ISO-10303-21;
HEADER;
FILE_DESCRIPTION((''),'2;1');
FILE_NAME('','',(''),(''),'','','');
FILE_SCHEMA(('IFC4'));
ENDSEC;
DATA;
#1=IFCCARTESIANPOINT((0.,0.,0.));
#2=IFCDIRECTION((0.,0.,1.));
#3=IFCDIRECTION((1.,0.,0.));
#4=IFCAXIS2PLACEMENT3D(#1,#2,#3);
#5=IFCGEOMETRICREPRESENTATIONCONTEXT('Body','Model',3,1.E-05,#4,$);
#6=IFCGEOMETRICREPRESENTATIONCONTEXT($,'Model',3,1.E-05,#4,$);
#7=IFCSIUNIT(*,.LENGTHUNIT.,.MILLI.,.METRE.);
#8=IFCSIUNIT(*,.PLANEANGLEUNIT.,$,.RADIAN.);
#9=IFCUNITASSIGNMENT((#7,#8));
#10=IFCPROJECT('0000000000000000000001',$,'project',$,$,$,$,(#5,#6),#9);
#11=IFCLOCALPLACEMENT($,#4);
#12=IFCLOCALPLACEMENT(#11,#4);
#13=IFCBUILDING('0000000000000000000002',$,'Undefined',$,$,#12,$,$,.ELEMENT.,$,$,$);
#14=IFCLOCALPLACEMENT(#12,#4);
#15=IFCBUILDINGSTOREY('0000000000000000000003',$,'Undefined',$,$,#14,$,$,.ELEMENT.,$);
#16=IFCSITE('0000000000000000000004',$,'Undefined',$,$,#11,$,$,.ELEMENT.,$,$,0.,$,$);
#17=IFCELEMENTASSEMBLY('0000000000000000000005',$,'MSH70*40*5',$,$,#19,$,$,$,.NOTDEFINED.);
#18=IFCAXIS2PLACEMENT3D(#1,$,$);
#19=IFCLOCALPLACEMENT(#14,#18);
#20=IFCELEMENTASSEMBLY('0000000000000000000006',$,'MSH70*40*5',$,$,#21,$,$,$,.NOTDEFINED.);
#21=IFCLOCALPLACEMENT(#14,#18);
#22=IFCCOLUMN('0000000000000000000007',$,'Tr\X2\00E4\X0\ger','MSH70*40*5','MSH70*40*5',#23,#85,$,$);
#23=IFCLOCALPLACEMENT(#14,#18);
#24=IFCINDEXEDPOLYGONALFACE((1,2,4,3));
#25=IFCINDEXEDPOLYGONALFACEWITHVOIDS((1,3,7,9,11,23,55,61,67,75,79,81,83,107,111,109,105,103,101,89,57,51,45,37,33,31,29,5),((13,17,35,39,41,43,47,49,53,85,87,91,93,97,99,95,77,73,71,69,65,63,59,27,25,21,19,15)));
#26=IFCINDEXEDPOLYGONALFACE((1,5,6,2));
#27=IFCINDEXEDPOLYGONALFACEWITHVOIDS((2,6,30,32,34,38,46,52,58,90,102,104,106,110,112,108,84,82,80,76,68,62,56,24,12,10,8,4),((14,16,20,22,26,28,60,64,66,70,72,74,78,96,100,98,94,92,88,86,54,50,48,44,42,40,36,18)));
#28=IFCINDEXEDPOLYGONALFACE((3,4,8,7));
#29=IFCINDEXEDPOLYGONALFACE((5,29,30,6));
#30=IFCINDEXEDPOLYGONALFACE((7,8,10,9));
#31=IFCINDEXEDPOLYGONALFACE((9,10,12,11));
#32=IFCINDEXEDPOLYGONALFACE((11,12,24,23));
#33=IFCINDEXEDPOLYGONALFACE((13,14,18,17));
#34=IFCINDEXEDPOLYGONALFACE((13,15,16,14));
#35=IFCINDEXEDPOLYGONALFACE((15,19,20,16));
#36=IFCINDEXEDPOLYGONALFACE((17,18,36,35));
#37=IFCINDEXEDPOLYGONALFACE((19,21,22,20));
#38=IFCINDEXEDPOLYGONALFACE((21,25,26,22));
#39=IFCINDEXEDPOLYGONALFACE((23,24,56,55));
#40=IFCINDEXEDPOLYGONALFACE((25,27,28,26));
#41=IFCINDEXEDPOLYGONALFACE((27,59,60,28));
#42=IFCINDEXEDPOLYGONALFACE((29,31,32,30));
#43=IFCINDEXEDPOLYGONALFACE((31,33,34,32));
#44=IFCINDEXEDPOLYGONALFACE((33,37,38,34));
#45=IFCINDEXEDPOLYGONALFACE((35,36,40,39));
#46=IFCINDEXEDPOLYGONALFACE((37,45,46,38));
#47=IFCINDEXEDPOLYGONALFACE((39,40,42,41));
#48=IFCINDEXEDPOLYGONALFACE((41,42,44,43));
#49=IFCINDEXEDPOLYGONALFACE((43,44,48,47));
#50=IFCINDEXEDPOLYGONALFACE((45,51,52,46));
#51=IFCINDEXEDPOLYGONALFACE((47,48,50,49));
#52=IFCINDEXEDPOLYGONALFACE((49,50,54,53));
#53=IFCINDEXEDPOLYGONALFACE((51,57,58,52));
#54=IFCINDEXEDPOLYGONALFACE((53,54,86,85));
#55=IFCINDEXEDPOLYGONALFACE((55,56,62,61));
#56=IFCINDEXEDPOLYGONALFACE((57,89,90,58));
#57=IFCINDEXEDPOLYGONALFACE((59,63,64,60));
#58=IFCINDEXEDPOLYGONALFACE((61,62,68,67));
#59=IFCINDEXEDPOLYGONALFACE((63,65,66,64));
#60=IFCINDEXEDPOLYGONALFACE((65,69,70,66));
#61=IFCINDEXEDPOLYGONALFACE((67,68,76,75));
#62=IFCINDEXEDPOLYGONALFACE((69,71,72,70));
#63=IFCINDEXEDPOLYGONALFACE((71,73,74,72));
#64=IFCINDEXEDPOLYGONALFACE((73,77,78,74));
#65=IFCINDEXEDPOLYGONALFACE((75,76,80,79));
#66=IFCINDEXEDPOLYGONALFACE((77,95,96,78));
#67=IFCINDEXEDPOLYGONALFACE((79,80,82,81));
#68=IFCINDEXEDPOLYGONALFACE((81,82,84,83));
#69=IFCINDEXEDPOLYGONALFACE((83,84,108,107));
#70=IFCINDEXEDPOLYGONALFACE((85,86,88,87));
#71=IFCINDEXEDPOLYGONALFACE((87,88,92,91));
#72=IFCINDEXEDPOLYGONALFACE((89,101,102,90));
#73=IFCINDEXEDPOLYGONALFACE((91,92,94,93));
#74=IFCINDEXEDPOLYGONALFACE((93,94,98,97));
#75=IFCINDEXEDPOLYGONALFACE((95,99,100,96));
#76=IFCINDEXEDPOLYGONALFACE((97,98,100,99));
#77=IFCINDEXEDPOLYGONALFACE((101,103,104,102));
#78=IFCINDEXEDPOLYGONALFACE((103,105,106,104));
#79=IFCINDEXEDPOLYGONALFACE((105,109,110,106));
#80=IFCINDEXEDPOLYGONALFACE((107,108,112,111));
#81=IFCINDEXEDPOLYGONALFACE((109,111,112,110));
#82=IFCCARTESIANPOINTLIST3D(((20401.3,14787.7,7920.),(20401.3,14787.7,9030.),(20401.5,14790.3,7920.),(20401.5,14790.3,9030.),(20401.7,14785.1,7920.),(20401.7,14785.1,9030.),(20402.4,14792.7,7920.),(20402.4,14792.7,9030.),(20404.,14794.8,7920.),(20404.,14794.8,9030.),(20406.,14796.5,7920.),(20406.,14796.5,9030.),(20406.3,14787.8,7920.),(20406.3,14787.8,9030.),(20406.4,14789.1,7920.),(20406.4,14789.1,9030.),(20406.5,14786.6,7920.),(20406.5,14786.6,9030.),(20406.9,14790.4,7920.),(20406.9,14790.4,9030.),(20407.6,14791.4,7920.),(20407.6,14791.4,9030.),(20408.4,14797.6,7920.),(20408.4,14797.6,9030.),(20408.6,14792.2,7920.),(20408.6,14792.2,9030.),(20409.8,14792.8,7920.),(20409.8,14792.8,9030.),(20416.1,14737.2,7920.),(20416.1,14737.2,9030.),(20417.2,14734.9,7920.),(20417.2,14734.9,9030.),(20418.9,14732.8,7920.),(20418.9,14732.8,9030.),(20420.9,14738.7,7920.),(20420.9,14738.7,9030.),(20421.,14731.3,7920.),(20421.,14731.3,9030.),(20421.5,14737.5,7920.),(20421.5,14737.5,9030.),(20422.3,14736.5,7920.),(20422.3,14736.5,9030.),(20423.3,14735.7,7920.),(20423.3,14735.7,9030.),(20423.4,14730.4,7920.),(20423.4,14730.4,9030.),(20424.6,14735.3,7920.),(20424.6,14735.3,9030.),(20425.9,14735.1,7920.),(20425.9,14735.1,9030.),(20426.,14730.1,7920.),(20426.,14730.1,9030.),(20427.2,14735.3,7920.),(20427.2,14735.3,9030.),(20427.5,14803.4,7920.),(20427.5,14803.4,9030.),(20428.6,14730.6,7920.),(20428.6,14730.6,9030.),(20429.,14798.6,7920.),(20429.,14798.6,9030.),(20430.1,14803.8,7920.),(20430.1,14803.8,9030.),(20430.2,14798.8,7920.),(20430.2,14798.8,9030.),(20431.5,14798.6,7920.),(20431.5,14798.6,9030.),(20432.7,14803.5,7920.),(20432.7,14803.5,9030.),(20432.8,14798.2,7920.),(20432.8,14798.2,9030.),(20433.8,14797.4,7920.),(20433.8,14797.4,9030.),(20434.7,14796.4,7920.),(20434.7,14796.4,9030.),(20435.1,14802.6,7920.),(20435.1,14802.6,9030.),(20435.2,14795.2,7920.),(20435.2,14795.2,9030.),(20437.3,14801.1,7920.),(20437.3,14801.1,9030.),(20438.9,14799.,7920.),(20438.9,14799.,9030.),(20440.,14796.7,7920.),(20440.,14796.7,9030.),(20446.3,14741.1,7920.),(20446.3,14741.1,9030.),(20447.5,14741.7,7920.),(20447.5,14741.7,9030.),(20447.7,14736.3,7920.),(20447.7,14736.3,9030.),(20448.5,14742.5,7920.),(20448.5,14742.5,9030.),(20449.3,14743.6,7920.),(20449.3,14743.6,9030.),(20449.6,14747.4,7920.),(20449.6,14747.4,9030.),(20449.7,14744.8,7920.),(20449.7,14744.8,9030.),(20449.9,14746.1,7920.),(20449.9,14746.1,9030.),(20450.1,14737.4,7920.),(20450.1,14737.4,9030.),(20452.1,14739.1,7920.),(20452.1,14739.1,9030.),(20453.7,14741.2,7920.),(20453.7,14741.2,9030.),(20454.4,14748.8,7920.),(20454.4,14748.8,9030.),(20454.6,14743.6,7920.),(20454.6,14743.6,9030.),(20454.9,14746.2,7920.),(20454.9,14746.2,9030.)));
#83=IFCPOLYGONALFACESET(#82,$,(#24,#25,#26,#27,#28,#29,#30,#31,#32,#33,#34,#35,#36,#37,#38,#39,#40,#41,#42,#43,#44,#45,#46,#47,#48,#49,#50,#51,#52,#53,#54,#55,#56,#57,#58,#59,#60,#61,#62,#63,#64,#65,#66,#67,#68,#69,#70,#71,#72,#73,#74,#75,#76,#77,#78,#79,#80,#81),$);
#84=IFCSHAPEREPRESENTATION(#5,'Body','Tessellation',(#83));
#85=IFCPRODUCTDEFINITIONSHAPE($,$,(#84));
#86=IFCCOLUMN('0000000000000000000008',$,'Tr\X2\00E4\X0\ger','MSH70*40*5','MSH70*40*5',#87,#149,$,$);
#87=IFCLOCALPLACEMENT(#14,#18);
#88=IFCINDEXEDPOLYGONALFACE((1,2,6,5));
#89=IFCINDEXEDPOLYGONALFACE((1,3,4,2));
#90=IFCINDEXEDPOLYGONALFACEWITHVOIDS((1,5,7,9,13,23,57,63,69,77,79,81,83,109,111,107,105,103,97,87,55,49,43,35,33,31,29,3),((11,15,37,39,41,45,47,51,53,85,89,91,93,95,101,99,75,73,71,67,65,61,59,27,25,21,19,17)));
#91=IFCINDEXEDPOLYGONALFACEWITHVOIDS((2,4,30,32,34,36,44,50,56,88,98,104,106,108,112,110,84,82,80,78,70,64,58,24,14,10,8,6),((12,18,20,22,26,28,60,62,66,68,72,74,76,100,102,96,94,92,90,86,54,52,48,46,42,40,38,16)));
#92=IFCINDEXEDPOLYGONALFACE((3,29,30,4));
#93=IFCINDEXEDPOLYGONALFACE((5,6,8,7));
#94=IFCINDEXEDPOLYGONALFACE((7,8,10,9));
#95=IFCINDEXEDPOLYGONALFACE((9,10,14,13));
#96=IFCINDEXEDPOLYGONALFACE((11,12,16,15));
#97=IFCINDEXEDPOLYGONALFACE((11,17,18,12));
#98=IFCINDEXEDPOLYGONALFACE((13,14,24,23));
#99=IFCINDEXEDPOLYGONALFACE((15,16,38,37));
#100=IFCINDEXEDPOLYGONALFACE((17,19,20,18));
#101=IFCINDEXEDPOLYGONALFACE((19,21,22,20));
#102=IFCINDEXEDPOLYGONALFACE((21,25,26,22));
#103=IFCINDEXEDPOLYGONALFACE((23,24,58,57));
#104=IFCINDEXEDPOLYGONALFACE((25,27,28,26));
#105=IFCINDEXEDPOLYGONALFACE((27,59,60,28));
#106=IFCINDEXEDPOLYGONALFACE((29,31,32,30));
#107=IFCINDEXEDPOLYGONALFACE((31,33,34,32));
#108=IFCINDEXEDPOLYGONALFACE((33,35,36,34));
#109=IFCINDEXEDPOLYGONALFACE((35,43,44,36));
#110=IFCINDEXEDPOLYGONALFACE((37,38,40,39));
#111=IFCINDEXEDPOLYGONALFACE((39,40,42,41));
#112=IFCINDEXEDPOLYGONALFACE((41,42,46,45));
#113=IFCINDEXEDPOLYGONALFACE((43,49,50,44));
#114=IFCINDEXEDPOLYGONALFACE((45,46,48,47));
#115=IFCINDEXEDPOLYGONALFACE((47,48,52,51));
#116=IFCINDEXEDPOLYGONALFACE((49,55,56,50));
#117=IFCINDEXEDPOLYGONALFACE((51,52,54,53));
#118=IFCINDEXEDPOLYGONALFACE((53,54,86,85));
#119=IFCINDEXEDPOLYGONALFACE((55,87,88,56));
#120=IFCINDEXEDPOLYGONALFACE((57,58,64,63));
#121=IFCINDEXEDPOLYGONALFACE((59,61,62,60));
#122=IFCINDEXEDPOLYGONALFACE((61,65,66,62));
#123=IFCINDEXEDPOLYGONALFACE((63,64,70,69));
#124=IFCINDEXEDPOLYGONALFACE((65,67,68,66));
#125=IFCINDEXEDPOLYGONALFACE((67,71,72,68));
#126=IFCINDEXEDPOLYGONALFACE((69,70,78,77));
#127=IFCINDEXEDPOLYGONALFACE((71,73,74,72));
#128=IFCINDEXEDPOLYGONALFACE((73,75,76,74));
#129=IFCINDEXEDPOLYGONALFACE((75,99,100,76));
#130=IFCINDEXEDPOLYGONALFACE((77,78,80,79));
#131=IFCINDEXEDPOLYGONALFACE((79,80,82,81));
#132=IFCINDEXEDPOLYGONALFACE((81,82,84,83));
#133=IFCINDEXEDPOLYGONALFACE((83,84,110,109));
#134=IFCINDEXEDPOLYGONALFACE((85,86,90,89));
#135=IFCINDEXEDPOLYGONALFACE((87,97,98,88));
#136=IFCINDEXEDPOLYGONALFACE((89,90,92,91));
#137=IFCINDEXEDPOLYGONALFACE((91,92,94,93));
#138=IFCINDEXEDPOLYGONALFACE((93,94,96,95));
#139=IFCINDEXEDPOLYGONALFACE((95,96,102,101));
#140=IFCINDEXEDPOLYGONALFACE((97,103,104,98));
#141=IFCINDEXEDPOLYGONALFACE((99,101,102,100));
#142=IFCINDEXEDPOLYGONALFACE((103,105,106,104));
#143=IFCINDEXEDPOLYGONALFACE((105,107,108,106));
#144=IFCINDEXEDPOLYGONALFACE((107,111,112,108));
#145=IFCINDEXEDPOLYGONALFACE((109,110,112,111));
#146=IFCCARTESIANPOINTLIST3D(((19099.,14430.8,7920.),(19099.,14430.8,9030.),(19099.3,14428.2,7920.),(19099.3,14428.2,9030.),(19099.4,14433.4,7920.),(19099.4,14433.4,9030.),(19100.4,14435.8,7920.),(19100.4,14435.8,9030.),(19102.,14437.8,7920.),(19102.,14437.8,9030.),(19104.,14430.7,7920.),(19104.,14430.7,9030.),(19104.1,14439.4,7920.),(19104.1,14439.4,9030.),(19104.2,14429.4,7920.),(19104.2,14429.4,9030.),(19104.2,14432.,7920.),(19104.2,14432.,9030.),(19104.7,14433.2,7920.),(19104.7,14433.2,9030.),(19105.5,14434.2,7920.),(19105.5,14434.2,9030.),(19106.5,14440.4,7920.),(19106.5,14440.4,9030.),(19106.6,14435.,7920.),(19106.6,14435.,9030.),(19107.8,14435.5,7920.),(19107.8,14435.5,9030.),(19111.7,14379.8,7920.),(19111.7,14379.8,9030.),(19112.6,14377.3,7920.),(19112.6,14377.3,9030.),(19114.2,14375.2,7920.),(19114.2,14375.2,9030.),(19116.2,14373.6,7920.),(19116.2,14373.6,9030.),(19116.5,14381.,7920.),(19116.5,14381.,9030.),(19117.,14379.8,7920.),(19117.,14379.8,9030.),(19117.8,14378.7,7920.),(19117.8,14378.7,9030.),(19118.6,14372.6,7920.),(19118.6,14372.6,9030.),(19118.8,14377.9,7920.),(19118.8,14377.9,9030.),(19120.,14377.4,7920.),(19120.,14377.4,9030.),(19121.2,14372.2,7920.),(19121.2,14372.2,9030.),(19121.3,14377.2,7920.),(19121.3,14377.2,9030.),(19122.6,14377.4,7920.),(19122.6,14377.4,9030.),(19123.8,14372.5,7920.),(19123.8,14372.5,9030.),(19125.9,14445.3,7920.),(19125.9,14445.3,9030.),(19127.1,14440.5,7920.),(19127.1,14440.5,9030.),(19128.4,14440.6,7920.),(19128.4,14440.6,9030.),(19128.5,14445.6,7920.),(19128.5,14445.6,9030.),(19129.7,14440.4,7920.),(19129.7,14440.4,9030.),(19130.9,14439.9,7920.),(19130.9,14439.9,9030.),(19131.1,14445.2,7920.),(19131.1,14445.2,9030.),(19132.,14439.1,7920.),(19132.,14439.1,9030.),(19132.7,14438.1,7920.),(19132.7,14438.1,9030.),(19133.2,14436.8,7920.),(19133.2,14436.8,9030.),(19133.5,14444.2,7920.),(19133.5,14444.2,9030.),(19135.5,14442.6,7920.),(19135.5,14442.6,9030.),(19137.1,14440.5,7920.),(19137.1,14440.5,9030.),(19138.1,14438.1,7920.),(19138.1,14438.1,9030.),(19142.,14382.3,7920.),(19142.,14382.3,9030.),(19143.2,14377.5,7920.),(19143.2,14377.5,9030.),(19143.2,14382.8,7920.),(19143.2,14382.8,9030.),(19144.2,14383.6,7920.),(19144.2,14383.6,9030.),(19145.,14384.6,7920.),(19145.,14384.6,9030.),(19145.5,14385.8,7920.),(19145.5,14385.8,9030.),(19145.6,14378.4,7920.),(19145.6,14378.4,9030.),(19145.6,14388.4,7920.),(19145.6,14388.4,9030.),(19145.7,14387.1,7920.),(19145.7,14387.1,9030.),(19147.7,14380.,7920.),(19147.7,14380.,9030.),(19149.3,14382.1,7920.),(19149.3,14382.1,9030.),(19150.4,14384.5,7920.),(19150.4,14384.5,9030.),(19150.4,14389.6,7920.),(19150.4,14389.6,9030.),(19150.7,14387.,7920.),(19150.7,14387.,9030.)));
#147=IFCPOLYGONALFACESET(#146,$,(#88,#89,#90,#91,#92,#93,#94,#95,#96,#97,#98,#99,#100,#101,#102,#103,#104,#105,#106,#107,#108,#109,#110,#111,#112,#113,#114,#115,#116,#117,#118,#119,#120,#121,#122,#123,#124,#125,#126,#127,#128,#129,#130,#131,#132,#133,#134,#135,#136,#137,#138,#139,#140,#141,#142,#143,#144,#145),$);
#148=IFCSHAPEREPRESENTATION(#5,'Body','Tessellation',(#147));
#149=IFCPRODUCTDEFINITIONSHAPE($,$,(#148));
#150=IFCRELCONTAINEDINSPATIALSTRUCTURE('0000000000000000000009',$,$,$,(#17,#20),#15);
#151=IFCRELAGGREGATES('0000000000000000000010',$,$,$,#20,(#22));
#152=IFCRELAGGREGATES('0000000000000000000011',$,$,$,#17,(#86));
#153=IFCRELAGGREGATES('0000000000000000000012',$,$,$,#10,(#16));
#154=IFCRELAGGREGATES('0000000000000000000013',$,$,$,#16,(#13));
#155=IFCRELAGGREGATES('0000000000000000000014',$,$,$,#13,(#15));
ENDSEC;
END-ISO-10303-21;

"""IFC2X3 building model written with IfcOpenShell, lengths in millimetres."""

from ifc_helpers import new_model, si_unit, frame, origin_with_axes, origin_2d_with_axis, place, context, project, spatial, hollow_rectangle, extrude, element, aggregate, save


model = new_model("IFC2X3")

# Units and contexts
model_context_1 = context("Model", 3, precision=1e-05, world=origin_with_axes(), identifier="Body")
model_context_2 = context("Model", 3, precision=1e-05, world=origin_with_axes())
ifc_project = project(units=[si_unit("LENGTHUNIT", "METRE", prefix="MILLI"), si_unit("PLANEANGLEUNIT", "RADIAN")], contexts=[model_context_1, model_context_2])

# Site, building, storey
site_placement = place(None, origin_with_axes())
site = spatial("IfcSite", under=ifc_project, at=site_placement, Name="Undefined", CompositionType="ELEMENT", RefElevation=0.0)
building_placement = place(site_placement, origin_with_axes())
building = spatial("IfcBuilding", under=site, at=building_placement, Name="Undefined", CompositionType="ELEMENT")
storey_placement = place(building_placement, origin_with_axes())
storey = spatial("IfcBuildingStorey", under=building, at=storey_placement, Name="Undefined", CompositionType="ELEMENT")

# Element assembly
assembly_1 = element("IfcElementAssembly", 1, inside=storey, Name="MSH70*40*5", PredefinedType="NOTDEFINED")

# Element assembly, column
assembly_2 = element("IfcElementAssembly", 2, inside=storey, Name="MSH70*40*5", PredefinedType="NOTDEFINED")
column_1_placement = place(storey_placement, frame((20428.1, 14767.0, 7920.0), z_axis=(0.0, 0.0, 1.0), x_axis=(1.0, 0.0, 0.0)))
column_1 = element("IfcColumn", 3, at=column_1_placement, Name="Träger", Description="MSH70*40*5", ObjectType="MSH70*40*5", context=model_context_1, shape_type="SweptSolid", body=[
    extrude(hollow_rectangle(XDim=40.0, YDim=70.0, WallThickness=5.0, InnerFilletRadius=5.0, OuterFilletRadius=10.0, at=origin_2d_with_axis()), frame((0.0, 0.0, 1110.0), z_axis=(0.0, 0.0, -1.0), x_axis=(-0.957319, -0.289033, 0.000005)), (0.0, 0.0, 1.0), 1110.0),
])
aggregate(assembly_2, [column_1])

# Column
column_2_placement = place(storey_placement, frame((19124.9, 14408.9, 7920.0), z_axis=(0.0, 0.0, 1.0), x_axis=(1.0, 0.0, 0.0)))
column_2 = element("IfcColumn", 4, at=column_2_placement, Name="Träger", Description="MSH70*40*5", ObjectType="MSH70*40*5", context=model_context_1, shape_type="SweptSolid", body=[
    extrude(hollow_rectangle(XDim=40.0, YDim=70.0, WallThickness=5.0, InnerFilletRadius=5.0, OuterFilletRadius=10.0, at=origin_2d_with_axis()), frame((0.0, 0.0, 1110.0), z_axis=(0.0, 0.0, -1.0), x_axis=(-0.969016, -0.247, 0.000005)), (0.0, 0.0, 1.0), 1110.0),
])
aggregate(assembly_1, [column_2])

save(model, "model.ifc")
